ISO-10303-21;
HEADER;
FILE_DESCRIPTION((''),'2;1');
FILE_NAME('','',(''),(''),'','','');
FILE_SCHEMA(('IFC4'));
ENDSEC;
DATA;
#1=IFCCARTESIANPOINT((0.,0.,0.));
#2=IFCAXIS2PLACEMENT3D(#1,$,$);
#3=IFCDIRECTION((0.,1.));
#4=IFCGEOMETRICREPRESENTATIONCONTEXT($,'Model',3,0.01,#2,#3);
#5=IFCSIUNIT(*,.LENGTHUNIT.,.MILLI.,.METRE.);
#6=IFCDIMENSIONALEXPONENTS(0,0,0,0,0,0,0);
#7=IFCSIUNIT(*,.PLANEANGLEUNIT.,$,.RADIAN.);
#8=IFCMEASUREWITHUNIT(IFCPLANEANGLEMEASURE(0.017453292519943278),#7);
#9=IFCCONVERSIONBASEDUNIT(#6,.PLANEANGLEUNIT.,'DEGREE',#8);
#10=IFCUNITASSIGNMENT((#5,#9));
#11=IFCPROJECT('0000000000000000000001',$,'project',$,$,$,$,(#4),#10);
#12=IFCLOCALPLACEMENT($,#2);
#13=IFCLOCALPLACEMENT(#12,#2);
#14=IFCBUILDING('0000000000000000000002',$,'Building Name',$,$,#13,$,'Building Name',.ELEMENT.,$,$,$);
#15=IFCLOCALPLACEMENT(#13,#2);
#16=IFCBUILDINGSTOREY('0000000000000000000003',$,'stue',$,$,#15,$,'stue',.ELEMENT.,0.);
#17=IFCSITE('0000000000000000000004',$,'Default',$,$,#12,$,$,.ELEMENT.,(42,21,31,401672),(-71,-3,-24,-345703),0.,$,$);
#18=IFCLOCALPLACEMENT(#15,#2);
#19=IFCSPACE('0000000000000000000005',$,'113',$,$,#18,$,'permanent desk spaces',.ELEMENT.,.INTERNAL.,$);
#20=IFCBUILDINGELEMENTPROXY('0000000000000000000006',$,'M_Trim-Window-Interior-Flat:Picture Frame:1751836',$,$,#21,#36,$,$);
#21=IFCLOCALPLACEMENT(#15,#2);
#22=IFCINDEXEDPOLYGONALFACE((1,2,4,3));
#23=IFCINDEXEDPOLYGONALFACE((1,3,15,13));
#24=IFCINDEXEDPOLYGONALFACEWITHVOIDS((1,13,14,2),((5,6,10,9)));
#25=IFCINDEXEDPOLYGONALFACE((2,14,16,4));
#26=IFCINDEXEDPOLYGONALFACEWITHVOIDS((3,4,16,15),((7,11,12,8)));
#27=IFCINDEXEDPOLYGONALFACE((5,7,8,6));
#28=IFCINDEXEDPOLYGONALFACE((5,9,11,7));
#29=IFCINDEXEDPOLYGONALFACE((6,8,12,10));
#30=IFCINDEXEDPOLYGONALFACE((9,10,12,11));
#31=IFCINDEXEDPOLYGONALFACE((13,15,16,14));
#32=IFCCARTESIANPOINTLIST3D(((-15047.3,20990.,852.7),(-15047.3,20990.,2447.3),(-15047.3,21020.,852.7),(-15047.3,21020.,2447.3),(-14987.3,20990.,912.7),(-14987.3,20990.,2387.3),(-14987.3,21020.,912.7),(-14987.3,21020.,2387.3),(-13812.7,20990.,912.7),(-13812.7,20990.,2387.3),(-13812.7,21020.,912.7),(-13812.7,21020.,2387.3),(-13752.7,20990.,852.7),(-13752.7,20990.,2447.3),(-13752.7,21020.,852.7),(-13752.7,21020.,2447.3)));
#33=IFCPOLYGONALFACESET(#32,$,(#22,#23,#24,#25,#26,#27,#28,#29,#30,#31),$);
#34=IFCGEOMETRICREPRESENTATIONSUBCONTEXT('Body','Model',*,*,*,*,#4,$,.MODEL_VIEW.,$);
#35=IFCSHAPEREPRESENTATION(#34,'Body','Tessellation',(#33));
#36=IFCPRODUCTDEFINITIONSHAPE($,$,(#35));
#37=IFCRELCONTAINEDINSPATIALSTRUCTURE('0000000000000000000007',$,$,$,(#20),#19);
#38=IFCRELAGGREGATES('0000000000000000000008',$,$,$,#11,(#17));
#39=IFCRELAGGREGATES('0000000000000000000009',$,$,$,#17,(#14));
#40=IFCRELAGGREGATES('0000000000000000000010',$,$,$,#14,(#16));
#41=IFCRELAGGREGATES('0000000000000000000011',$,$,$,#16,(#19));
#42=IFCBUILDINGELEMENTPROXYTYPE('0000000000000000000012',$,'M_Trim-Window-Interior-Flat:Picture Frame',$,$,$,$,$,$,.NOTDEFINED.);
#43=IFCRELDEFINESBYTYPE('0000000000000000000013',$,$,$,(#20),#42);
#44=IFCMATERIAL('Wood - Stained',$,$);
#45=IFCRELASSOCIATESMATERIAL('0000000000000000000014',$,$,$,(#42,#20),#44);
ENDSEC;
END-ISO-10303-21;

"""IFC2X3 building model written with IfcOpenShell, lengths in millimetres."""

from ifc_helpers import new_model, entity, si_unit, converted_unit, direction, frame, origin, place, context, subcontext, project, spatial, polyline, outline, extrude, source, transform, mapped, material, type_object, type_shapes, element, save


model = new_model("IFC2X3")

# Units and contexts
model_context = context("Model", 3, precision=0.01, world=origin(), true_north=direction((0.0, 1.0)))
body_context = subcontext(model_context, "Body", "Model", "MODEL_VIEW")
ifc_project = project(units=[si_unit("LENGTHUNIT", "METRE", prefix="MILLI"), converted_unit("PLANEANGLEUNIT", "DEGREE", entity("IfcPlaneAngleMeasure", 0.017453292519943278), si_unit("PLANEANGLEUNIT", "RADIAN"), dimensions=[0, 0, 0, 0, 0, 0, 0])], contexts=[model_context])

# Site, building, storey
site_placement = place(None, origin())
site = spatial("IfcSite", under=ifc_project, at=site_placement, Name="Default", CompositionType="ELEMENT", RefLatitude=(42, 21, 31, 401672), RefLongitude=(-71, -3, -24, -345703), RefElevation=0.0)
building_placement = place(site_placement, origin())
building = spatial("IfcBuilding", under=site, at=building_placement, Name="Building Name", LongName="Building Name", CompositionType="ELEMENT")
storey_placement = place(building_placement, origin())
storey = spatial("IfcBuildingStorey", under=building, at=storey_placement, Name="stue", LongName="stue", CompositionType="ELEMENT", Elevation=0.0)

# Shared definitions
ifc_material_1 = material(Name="Wood - Stained")

# Shared definitions
building_element_proxy_type_1 = type_object("IfcBuildingElementProxyType", Name="M_Trim-Window-Interior-Flat:Picture Frame", PredefinedType="NOTDEFINED", material=ifc_material_1)
shared_shape_1 = source(origin(), body_context, "Body", "SweptSolid", [
    extrude(outline(polyline([(-647.3, -797.3), (647.3, -797.3), (647.3, 797.3), (-647.3, 797.3), (-647.3, -797.3)]), holes=[polyline([(-587.3, -737.3), (-587.3, 737.3), (587.3, 737.3), (587.3, -737.3), (-587.3, -737.3)])]), frame((0.0, -750.0, 0.0), z_axis=(0.0, 0.0, 1.0), x_axis=(-1.0, 0.0, 0.0)), (0.0, 0.0, 1.0), 30.0),
])
type_shapes(building_element_proxy_type_1, [shared_shape_1])

# Shared definitions
space_1_placement = place(storey_placement, origin())
space_1 = spatial("IfcSpace", under=storey, at=space_1_placement, Name="113", LongName="permanent desk spaces", CompositionType="ELEMENT", InteriorOrExteriorSpace="INTERNAL")

# Building element proxy
for number, where, z_axis, x_axis, name in (
    (1, (-14400.0, 21020.0, 2400.0), (0.0, -1.0, 0.0), (1.0, 0.0, 0.0), "M_Trim-Window-Interior-Flat:Picture Frame:1751836"),
):
    element("IfcBuildingElementProxy", number, at=place(space_1_placement, frame(where, z_axis=z_axis, x_axis=x_axis)), inside=space_1, type_object=building_element_proxy_type_1, material=ifc_material_1, Name=name, context=body_context, shape_type="MappedRepresentation", body=[
        mapped(shared_shape_1, transform((0.0, 0.0, 0.0), scale=1.0)),
    ])

save(model, "model.ifc")
